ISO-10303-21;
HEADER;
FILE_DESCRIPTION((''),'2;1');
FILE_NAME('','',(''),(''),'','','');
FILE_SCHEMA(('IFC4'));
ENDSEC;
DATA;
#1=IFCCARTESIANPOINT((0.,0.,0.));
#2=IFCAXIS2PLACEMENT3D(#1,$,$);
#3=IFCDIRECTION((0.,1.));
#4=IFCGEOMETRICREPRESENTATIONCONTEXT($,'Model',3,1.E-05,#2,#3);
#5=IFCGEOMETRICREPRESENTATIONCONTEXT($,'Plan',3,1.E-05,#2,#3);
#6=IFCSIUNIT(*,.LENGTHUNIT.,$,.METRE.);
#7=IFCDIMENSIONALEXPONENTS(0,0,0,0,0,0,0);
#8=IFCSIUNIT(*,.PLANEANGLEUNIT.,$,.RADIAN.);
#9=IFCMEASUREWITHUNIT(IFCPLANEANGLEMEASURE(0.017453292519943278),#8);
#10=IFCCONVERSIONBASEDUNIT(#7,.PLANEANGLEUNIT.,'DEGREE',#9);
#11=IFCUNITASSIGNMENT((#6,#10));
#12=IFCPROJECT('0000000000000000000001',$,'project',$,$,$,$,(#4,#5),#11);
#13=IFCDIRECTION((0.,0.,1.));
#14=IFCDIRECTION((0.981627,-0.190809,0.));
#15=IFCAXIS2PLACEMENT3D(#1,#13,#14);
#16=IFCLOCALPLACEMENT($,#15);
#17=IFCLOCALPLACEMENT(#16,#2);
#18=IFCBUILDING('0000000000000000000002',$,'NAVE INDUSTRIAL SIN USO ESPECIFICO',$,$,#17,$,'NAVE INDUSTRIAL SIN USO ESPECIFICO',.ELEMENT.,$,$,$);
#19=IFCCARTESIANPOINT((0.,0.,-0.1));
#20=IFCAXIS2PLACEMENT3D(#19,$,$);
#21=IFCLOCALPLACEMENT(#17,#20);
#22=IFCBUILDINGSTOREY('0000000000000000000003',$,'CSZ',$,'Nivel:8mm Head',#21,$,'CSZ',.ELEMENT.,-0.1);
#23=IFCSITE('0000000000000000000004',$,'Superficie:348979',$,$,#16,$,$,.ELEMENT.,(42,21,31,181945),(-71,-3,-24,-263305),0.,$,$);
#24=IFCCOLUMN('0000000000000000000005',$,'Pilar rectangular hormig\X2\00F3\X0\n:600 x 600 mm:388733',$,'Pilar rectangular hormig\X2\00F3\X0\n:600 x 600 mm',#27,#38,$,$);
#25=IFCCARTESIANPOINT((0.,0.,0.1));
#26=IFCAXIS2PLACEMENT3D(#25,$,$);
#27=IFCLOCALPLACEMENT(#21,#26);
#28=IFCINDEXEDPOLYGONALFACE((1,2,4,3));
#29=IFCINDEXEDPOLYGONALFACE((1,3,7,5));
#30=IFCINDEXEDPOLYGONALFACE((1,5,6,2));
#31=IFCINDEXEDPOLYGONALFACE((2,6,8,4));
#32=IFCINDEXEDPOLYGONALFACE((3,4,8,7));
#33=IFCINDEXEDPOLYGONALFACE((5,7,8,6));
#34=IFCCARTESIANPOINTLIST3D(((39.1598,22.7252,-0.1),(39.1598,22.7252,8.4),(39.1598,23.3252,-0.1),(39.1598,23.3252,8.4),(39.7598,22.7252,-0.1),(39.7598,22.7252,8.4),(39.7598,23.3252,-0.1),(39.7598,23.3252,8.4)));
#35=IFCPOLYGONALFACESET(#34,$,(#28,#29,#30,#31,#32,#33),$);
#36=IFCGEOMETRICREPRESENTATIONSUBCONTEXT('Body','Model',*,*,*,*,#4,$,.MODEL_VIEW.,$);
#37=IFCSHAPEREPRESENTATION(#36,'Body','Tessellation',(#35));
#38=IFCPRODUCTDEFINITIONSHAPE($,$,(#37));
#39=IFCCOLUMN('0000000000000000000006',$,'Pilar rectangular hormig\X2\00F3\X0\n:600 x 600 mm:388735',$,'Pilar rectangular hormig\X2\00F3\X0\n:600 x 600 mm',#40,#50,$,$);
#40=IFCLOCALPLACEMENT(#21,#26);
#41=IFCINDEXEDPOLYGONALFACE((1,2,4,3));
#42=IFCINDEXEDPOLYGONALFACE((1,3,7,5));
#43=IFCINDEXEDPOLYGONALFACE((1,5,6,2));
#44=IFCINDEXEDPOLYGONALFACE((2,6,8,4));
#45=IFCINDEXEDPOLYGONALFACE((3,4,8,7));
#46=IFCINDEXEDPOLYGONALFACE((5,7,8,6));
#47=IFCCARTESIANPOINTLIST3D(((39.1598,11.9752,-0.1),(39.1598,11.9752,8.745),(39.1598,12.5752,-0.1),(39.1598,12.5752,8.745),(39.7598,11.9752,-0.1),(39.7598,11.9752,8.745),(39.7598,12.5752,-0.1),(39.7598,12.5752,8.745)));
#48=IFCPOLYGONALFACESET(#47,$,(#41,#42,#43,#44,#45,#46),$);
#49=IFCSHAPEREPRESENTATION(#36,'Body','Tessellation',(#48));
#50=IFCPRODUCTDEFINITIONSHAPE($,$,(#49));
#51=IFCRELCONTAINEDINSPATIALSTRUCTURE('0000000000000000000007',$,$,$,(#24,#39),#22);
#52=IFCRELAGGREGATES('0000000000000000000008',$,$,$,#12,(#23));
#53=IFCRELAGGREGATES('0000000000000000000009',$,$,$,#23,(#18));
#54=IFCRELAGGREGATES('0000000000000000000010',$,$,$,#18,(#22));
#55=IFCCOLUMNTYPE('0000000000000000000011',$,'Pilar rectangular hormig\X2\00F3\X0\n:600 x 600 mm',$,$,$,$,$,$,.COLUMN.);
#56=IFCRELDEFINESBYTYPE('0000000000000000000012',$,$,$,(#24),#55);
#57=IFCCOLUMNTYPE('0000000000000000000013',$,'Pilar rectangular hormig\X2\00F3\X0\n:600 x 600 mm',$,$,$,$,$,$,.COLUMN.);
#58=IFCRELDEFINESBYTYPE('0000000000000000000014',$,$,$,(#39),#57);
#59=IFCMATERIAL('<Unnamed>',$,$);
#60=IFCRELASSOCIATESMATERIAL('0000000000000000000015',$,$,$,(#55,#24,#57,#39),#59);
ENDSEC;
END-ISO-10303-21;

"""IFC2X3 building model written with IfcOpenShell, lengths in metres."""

from ifc_helpers import new_model, entity, si_unit, converted_unit, direction, frame, frame_2d, origin, place, context, subcontext, project, spatial, rectangle, extrude, source, transform, mapped, material, type_object, type_shapes, element, save


model = new_model("IFC2X3")

# Units and contexts
model_context = context("Model", 3, precision=1e-05, world=origin(), true_north=direction((0.0, 1.0)))
plan_context = context("Plan", 3, precision=1e-05, world=origin(), true_north=direction((0.0, 1.0)))
body_context = subcontext(model_context, "Body", "Model", "MODEL_VIEW")
ifc_project = project(units=[si_unit("LENGTHUNIT", "METRE"), converted_unit("PLANEANGLEUNIT", "DEGREE", entity("IfcPlaneAngleMeasure", 0.017453292519943278), si_unit("PLANEANGLEUNIT", "RADIAN"), dimensions=[0, 0, 0, 0, 0, 0, 0])], contexts=[model_context, plan_context])

# Site, building, storey
site_placement = place(None, frame((0.0, 0.0, 0.0), z_axis=(0.0, 0.0, 1.0), x_axis=(0.981627, -0.190809, 0.0)))
site = spatial("IfcSite", under=ifc_project, at=site_placement, Name="Superficie:348979", CompositionType="ELEMENT", RefLatitude=(42, 21, 31, 181945), RefLongitude=(-71, -3, -24, -263305), RefElevation=0.0)
building_placement = place(site_placement, origin())
building = spatial("IfcBuilding", under=site, at=building_placement, Name="NAVE INDUSTRIAL SIN USO ESPECIFICO", LongName="NAVE INDUSTRIAL SIN USO ESPECIFICO", CompositionType="ELEMENT")
storey_placement = place(building_placement, frame((0.0, 0.0, -0.1)))
storey = spatial("IfcBuildingStorey", under=building, at=storey_placement, Name="CSZ", ObjectType="Nivel:8mm Head", LongName="CSZ", CompositionType="ELEMENT", Elevation=-0.1)

# Columns
ifc_material_1 = material(Name="<Unnamed>")
column_type_1 = type_object("IfcColumnType", Name="Pilar rectangular hormigón:600 x 600 mm", PredefinedType="COLUMN", material=ifc_material_1)
shared_shape_1 = source(origin(), body_context, "Body", "SweptSolid", [
    extrude(rectangle(XDim=0.6, YDim=0.6, at=frame_2d((0.0, 0.0), x_axis=(1.0, 0.0))), frame((39.4598, 23.0252, -0.1), z_axis=(0.0, 0.0, 1.0), x_axis=(-1.0, 0.0, 0.0)), (0.0, 0.0, 1.0), 8.5),
])
type_shapes(column_type_1, [shared_shape_1])
column_1_placement = place(storey_placement, frame((0.0, 0.0, 0.1)))
element("IfcColumn", 1, at=column_1_placement, inside=storey, type_object=column_type_1, material=ifc_material_1, Name="Pilar rectangular hormigón:600 x 600 mm:388733", ObjectType="Pilar rectangular hormigón:600 x 600 mm", context=body_context, shape_type="MappedRepresentation", body=[
    mapped(shared_shape_1, transform((0.0, 0.0, 0.0), scale=1.0)),
])
column_type_2 = type_object("IfcColumnType", Name="Pilar rectangular hormigón:600 x 600 mm", PredefinedType="COLUMN", material=ifc_material_1)
shared_shape_2 = source(origin(), body_context, "Body", "SweptSolid", [
    extrude(rectangle(XDim=0.6, YDim=0.6, at=frame_2d((0.0, 0.0), x_axis=(1.0, 0.0))), frame((39.4598, 12.2752, -0.1), z_axis=(0.0, 0.0, 1.0), x_axis=(-1.0, 0.0, 0.0)), (0.0, 0.0, 1.0), 8.845),
])
type_shapes(column_type_2, [shared_shape_2])
column_2_placement = place(storey_placement, frame((0.0, 0.0, 0.1)))
element("IfcColumn", 2, at=column_2_placement, inside=storey, type_object=column_type_2, material=ifc_material_1, Name="Pilar rectangular hormigón:600 x 600 mm:388735", ObjectType="Pilar rectangular hormigón:600 x 600 mm", context=body_context, shape_type="MappedRepresentation", body=[
    mapped(shared_shape_2, transform((0.0, 0.0, 0.0), scale=1.0)),
])

save(model, "model.ifc")
